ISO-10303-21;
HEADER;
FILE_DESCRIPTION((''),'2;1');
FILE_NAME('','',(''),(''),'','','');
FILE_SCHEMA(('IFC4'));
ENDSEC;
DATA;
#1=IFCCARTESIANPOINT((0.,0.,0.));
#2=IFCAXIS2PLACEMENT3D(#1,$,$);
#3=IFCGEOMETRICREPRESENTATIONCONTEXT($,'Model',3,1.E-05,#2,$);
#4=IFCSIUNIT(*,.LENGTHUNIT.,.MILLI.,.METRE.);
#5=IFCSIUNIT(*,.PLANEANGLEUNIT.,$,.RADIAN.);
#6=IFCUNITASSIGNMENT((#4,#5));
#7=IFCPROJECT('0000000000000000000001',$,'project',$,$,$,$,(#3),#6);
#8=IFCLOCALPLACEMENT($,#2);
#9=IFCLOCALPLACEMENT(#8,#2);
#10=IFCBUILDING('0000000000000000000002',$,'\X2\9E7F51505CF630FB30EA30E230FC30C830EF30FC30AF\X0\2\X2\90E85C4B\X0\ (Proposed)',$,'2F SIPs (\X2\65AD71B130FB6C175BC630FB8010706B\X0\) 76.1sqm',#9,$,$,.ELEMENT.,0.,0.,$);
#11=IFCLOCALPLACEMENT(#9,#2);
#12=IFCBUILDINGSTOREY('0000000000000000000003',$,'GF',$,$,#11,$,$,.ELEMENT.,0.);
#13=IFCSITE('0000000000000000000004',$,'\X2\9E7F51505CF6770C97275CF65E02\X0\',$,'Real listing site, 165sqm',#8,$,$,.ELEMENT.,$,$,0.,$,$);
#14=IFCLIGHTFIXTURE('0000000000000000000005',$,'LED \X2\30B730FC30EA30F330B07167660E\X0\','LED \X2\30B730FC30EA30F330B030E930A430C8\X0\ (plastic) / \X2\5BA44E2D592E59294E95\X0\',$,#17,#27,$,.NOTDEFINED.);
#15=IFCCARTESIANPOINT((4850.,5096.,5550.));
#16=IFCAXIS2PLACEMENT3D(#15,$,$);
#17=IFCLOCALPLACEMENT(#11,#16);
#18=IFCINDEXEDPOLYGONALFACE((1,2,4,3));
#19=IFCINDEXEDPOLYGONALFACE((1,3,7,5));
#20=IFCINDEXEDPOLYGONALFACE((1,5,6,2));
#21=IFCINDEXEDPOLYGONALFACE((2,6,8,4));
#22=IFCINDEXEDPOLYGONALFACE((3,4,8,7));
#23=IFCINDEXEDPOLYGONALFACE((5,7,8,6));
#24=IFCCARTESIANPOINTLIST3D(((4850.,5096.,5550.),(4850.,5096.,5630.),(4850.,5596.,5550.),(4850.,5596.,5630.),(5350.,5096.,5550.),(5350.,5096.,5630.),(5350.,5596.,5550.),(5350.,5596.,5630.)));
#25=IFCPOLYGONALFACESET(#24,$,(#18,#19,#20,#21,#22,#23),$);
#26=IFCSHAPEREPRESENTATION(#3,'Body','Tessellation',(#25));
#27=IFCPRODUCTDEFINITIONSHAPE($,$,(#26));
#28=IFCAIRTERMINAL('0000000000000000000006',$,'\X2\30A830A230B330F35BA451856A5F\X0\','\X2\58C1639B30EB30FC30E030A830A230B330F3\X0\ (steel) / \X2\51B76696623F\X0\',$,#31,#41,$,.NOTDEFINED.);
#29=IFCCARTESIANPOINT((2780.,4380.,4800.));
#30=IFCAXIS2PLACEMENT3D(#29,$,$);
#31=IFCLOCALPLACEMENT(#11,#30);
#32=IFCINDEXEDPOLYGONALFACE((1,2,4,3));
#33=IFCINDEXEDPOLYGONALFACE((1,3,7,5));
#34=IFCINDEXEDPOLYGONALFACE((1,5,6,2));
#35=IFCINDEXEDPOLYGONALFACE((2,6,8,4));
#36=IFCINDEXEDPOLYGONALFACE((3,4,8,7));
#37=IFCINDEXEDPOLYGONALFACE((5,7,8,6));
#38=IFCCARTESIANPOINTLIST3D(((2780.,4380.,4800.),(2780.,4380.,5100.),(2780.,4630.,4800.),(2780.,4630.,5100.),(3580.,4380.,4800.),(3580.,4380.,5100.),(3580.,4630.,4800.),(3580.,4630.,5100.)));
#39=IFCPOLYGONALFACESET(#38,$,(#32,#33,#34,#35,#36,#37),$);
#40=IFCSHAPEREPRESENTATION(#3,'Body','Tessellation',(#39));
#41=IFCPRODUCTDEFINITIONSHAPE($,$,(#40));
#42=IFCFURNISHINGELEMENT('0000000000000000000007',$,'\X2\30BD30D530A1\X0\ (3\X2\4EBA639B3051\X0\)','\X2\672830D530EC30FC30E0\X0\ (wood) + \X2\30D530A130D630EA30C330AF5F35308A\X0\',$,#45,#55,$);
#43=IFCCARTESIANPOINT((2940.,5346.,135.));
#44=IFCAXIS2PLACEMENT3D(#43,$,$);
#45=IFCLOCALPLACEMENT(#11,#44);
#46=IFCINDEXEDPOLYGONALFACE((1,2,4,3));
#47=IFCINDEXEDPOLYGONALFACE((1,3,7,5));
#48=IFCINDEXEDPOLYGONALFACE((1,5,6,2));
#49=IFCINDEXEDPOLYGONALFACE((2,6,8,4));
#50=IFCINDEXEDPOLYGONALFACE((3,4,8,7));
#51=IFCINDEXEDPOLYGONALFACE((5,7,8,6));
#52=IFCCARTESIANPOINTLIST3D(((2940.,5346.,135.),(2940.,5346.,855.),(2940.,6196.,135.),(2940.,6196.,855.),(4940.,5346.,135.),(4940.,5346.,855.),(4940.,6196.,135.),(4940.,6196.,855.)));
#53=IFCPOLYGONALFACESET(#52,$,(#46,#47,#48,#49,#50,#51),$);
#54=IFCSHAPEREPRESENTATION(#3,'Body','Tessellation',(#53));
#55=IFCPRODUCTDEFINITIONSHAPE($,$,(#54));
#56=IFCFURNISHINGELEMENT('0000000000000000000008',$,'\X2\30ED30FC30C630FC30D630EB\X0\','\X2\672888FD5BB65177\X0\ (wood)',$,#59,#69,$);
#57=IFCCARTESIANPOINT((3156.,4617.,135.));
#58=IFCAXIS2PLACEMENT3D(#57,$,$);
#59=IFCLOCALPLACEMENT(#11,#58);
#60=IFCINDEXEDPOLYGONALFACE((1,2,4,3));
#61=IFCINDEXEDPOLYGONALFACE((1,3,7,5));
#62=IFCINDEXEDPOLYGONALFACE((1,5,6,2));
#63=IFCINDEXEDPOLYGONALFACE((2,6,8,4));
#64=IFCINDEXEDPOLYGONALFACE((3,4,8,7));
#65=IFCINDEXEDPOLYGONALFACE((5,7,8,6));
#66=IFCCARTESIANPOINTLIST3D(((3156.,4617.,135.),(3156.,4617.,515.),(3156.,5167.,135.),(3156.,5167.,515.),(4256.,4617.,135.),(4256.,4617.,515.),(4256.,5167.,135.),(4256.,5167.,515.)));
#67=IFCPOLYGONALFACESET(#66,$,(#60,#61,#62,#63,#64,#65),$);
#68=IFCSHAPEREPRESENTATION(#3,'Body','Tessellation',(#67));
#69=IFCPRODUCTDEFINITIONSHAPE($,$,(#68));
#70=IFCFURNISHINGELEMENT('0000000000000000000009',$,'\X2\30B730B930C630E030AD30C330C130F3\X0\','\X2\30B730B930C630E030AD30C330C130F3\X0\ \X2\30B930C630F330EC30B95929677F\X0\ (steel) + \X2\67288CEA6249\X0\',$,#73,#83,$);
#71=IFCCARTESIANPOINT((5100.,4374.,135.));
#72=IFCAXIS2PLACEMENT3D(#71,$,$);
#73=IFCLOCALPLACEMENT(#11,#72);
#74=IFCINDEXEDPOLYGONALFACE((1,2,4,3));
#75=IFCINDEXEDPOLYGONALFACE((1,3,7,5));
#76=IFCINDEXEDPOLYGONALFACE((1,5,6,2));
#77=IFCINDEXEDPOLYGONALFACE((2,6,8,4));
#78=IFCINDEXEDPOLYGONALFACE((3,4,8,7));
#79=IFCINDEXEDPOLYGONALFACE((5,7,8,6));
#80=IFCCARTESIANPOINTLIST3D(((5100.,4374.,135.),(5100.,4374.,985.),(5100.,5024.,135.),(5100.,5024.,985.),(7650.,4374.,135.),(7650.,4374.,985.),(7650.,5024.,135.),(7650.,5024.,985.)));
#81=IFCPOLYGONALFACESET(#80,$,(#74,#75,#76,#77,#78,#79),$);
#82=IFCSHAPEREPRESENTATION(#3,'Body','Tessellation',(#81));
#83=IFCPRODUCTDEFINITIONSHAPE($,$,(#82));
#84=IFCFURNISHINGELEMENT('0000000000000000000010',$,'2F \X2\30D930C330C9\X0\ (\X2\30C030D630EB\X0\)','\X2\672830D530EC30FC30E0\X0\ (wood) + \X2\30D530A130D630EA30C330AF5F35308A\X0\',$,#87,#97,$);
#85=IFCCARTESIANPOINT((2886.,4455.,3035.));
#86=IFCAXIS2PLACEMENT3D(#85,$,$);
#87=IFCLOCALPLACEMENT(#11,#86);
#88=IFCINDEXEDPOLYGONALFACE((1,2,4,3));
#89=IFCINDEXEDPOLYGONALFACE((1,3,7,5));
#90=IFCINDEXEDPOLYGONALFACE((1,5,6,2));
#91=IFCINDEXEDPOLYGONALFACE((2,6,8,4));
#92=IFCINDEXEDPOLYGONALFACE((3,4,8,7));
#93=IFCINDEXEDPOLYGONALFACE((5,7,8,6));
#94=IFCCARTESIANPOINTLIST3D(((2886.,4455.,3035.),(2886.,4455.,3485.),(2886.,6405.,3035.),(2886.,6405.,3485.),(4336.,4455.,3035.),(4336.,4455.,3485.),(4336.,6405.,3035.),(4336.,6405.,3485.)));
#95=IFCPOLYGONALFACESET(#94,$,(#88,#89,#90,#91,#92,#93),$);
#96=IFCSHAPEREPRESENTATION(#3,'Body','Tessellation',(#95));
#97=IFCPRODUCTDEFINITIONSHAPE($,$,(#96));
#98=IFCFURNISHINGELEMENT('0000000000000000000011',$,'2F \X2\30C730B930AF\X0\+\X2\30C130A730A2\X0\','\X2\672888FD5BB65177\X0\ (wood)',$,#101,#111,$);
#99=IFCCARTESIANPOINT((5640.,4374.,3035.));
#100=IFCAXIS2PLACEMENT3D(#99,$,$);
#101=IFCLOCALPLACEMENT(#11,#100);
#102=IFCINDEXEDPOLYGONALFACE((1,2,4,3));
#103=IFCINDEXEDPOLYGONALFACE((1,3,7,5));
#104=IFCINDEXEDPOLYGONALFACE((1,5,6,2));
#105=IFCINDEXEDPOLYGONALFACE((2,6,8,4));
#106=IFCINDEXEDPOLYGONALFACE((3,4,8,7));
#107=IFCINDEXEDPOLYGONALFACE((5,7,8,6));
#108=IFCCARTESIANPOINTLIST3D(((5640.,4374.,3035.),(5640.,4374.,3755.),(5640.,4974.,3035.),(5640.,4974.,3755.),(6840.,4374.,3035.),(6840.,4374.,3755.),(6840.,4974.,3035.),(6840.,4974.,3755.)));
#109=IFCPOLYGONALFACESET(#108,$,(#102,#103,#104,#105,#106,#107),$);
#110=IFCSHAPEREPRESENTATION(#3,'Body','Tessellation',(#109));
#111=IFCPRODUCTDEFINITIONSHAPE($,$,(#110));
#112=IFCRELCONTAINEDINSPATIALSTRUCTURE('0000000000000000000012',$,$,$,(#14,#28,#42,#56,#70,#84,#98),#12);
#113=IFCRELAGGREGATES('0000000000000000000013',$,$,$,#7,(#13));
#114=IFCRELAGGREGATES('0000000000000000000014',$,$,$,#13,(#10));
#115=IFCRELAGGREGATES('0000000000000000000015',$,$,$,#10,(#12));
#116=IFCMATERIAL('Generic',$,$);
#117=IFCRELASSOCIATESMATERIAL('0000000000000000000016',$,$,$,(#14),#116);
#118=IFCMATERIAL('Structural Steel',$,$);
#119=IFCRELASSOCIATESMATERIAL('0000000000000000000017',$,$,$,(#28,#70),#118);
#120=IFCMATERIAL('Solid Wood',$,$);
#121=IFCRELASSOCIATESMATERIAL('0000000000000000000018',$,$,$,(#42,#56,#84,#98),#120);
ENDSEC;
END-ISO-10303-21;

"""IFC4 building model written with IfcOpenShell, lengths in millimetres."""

from ifc_helpers import new_model, si_unit, frame, frame_2d, origin, place, context, project, spatial, rectangle, extrude, material, element, save


model = new_model("IFC4")

# Units and contexts
model_context = context("Model", 3, precision=1e-05, world=origin())
ifc_project = project(units=[si_unit("LENGTHUNIT", "METRE", prefix="MILLI"), si_unit("PLANEANGLEUNIT", "RADIAN")], contexts=[model_context])

# Site, building, storey
site_placement = place(None, origin())
site = spatial("IfcSite", under=ifc_project, at=site_placement, Name="鹿児島県霧島市", ObjectType="Real listing site, 165sqm", CompositionType="ELEMENT", RefElevation=0.0)
building_placement = place(site_placement, origin())
building = spatial("IfcBuilding", under=site, at=building_placement, Name="鹿児島・リモートワーク2部屋 (Proposed)", ObjectType="2F SIPs (断熱・気密・耐火) 76.1sqm", CompositionType="ELEMENT", ElevationOfRefHeight=0.0, ElevationOfTerrain=0.0)
storey_placement = place(building_placement, origin())
storey = spatial("IfcBuildingStorey", under=building, at=storey_placement, Name="GF", CompositionType="ELEMENT", Elevation=0.0)

# Shared definitions
ifc_material_1 = material(Name="Solid Wood")

# Shared definitions
ifc_material_2 = material(Name="Generic")

# Shared definitions
ifc_material_3 = material(Name="Structural Steel")

# Light fixture
light_fixture_1_placement = place(storey_placement, frame((4850.0, 5096.0, 5550.0)))
element("IfcLightFixture", 1, at=light_fixture_1_placement, inside=storey, material=ifc_material_2, Name="LED シーリング照明", Description="LED シーリングライト (plastic) / 室中央天井", PredefinedType="NOTDEFINED", context=model_context, shape_type="SweptSolid", body=[
    extrude(rectangle(XDim=500.0, YDim=500.0, at=frame_2d((250.0, 250.0))), frame((4850.0, 5096.0, 5550.0)), (0.0, 0.0, 1.0), 80.0),
])

# Air terminal
air_terminal_placement = place(storey_placement, frame((2780.0, 4380.0, 4800.0)))
element("IfcAirTerminal", 2, at=air_terminal_placement, inside=storey, material=ifc_material_3, Name="エアコン室内機", Description="壁掛ルームエアコン (steel) / 冷暖房", PredefinedType="NOTDEFINED", context=model_context, shape_type="SweptSolid", body=[
    extrude(rectangle(XDim=800.0, YDim=250.0, at=frame_2d((400.0, 125.0))), frame((2780.0, 4380.0, 4800.0)), (0.0, 0.0, 1.0), 300.0),
])

# Furnishing elements
furnishing_1_placement = place(storey_placement, frame((2940.0, 5346.0, 135.0)))
element("IfcFurnishingElement", 3, at=furnishing_1_placement, inside=storey, material=ifc_material_1, Name="ソファ (3人掛け)", Description="木フレーム (wood) + ファブリック張り", context=model_context, shape_type="SweptSolid", body=[
    extrude(rectangle(XDim=2000.0, YDim=850.0, at=frame_2d((1000.0, 425.0))), frame((2940.0, 5346.0, 135.0)), (0.0, 0.0, 1.0), 720.0),
])
furnishing_2_placement = place(storey_placement, frame((3156.0, 4617.0, 135.0)))
element("IfcFurnishingElement", 4, at=furnishing_2_placement, inside=storey, material=ifc_material_1, Name="ローテーブル", Description="木製家具 (wood)", context=model_context, shape_type="SweptSolid", body=[
    extrude(rectangle(XDim=1100.0, YDim=550.0, at=frame_2d((550.0, 275.0))), frame((3156.0, 4617.0, 135.0)), (0.0, 0.0, 1.0), 380.0),
])
furnishing_3_placement = place(storey_placement, frame((5100.0, 4374.0, 135.0)))
element("IfcFurnishingElement", 5, at=furnishing_3_placement, inside=storey, material=ifc_material_3, Name="システムキッチン", Description="システムキッチン ステンレス天板 (steel) + 木質扉", context=model_context, shape_type="SweptSolid", body=[
    extrude(rectangle(XDim=2550.0, YDim=650.0, at=frame_2d((1275.0, 325.0))), frame((5100.0, 4374.0, 135.0)), (0.0, 0.0, 1.0), 850.0),
])
furnishing_4_placement = place(storey_placement, frame((2886.0, 4455.0, 3035.0)))
element("IfcFurnishingElement", 6, at=furnishing_4_placement, inside=storey, material=ifc_material_1, Name="2F ベッド (ダブル)", Description="木フレーム (wood) + ファブリック張り", context=model_context, shape_type="SweptSolid", body=[
    extrude(rectangle(XDim=1450.0, YDim=1950.0, at=frame_2d((725.0, 975.0))), frame((2886.0, 4455.0, 3035.0)), (0.0, 0.0, 1.0), 450.0),
])
furnishing_5_placement = place(storey_placement, frame((5640.0, 4374.0, 3035.0)))
element("IfcFurnishingElement", 7, at=furnishing_5_placement, inside=storey, material=ifc_material_1, Name="2F デスク+チェア", Description="木製家具 (wood)", context=model_context, shape_type="SweptSolid", body=[
    extrude(rectangle(XDim=1200.0, YDim=600.0, at=frame_2d((600.0, 300.0))), frame((5640.0, 4374.0, 3035.0)), (0.0, 0.0, 1.0), 720.0),
])

save(model, "model.ifc")
